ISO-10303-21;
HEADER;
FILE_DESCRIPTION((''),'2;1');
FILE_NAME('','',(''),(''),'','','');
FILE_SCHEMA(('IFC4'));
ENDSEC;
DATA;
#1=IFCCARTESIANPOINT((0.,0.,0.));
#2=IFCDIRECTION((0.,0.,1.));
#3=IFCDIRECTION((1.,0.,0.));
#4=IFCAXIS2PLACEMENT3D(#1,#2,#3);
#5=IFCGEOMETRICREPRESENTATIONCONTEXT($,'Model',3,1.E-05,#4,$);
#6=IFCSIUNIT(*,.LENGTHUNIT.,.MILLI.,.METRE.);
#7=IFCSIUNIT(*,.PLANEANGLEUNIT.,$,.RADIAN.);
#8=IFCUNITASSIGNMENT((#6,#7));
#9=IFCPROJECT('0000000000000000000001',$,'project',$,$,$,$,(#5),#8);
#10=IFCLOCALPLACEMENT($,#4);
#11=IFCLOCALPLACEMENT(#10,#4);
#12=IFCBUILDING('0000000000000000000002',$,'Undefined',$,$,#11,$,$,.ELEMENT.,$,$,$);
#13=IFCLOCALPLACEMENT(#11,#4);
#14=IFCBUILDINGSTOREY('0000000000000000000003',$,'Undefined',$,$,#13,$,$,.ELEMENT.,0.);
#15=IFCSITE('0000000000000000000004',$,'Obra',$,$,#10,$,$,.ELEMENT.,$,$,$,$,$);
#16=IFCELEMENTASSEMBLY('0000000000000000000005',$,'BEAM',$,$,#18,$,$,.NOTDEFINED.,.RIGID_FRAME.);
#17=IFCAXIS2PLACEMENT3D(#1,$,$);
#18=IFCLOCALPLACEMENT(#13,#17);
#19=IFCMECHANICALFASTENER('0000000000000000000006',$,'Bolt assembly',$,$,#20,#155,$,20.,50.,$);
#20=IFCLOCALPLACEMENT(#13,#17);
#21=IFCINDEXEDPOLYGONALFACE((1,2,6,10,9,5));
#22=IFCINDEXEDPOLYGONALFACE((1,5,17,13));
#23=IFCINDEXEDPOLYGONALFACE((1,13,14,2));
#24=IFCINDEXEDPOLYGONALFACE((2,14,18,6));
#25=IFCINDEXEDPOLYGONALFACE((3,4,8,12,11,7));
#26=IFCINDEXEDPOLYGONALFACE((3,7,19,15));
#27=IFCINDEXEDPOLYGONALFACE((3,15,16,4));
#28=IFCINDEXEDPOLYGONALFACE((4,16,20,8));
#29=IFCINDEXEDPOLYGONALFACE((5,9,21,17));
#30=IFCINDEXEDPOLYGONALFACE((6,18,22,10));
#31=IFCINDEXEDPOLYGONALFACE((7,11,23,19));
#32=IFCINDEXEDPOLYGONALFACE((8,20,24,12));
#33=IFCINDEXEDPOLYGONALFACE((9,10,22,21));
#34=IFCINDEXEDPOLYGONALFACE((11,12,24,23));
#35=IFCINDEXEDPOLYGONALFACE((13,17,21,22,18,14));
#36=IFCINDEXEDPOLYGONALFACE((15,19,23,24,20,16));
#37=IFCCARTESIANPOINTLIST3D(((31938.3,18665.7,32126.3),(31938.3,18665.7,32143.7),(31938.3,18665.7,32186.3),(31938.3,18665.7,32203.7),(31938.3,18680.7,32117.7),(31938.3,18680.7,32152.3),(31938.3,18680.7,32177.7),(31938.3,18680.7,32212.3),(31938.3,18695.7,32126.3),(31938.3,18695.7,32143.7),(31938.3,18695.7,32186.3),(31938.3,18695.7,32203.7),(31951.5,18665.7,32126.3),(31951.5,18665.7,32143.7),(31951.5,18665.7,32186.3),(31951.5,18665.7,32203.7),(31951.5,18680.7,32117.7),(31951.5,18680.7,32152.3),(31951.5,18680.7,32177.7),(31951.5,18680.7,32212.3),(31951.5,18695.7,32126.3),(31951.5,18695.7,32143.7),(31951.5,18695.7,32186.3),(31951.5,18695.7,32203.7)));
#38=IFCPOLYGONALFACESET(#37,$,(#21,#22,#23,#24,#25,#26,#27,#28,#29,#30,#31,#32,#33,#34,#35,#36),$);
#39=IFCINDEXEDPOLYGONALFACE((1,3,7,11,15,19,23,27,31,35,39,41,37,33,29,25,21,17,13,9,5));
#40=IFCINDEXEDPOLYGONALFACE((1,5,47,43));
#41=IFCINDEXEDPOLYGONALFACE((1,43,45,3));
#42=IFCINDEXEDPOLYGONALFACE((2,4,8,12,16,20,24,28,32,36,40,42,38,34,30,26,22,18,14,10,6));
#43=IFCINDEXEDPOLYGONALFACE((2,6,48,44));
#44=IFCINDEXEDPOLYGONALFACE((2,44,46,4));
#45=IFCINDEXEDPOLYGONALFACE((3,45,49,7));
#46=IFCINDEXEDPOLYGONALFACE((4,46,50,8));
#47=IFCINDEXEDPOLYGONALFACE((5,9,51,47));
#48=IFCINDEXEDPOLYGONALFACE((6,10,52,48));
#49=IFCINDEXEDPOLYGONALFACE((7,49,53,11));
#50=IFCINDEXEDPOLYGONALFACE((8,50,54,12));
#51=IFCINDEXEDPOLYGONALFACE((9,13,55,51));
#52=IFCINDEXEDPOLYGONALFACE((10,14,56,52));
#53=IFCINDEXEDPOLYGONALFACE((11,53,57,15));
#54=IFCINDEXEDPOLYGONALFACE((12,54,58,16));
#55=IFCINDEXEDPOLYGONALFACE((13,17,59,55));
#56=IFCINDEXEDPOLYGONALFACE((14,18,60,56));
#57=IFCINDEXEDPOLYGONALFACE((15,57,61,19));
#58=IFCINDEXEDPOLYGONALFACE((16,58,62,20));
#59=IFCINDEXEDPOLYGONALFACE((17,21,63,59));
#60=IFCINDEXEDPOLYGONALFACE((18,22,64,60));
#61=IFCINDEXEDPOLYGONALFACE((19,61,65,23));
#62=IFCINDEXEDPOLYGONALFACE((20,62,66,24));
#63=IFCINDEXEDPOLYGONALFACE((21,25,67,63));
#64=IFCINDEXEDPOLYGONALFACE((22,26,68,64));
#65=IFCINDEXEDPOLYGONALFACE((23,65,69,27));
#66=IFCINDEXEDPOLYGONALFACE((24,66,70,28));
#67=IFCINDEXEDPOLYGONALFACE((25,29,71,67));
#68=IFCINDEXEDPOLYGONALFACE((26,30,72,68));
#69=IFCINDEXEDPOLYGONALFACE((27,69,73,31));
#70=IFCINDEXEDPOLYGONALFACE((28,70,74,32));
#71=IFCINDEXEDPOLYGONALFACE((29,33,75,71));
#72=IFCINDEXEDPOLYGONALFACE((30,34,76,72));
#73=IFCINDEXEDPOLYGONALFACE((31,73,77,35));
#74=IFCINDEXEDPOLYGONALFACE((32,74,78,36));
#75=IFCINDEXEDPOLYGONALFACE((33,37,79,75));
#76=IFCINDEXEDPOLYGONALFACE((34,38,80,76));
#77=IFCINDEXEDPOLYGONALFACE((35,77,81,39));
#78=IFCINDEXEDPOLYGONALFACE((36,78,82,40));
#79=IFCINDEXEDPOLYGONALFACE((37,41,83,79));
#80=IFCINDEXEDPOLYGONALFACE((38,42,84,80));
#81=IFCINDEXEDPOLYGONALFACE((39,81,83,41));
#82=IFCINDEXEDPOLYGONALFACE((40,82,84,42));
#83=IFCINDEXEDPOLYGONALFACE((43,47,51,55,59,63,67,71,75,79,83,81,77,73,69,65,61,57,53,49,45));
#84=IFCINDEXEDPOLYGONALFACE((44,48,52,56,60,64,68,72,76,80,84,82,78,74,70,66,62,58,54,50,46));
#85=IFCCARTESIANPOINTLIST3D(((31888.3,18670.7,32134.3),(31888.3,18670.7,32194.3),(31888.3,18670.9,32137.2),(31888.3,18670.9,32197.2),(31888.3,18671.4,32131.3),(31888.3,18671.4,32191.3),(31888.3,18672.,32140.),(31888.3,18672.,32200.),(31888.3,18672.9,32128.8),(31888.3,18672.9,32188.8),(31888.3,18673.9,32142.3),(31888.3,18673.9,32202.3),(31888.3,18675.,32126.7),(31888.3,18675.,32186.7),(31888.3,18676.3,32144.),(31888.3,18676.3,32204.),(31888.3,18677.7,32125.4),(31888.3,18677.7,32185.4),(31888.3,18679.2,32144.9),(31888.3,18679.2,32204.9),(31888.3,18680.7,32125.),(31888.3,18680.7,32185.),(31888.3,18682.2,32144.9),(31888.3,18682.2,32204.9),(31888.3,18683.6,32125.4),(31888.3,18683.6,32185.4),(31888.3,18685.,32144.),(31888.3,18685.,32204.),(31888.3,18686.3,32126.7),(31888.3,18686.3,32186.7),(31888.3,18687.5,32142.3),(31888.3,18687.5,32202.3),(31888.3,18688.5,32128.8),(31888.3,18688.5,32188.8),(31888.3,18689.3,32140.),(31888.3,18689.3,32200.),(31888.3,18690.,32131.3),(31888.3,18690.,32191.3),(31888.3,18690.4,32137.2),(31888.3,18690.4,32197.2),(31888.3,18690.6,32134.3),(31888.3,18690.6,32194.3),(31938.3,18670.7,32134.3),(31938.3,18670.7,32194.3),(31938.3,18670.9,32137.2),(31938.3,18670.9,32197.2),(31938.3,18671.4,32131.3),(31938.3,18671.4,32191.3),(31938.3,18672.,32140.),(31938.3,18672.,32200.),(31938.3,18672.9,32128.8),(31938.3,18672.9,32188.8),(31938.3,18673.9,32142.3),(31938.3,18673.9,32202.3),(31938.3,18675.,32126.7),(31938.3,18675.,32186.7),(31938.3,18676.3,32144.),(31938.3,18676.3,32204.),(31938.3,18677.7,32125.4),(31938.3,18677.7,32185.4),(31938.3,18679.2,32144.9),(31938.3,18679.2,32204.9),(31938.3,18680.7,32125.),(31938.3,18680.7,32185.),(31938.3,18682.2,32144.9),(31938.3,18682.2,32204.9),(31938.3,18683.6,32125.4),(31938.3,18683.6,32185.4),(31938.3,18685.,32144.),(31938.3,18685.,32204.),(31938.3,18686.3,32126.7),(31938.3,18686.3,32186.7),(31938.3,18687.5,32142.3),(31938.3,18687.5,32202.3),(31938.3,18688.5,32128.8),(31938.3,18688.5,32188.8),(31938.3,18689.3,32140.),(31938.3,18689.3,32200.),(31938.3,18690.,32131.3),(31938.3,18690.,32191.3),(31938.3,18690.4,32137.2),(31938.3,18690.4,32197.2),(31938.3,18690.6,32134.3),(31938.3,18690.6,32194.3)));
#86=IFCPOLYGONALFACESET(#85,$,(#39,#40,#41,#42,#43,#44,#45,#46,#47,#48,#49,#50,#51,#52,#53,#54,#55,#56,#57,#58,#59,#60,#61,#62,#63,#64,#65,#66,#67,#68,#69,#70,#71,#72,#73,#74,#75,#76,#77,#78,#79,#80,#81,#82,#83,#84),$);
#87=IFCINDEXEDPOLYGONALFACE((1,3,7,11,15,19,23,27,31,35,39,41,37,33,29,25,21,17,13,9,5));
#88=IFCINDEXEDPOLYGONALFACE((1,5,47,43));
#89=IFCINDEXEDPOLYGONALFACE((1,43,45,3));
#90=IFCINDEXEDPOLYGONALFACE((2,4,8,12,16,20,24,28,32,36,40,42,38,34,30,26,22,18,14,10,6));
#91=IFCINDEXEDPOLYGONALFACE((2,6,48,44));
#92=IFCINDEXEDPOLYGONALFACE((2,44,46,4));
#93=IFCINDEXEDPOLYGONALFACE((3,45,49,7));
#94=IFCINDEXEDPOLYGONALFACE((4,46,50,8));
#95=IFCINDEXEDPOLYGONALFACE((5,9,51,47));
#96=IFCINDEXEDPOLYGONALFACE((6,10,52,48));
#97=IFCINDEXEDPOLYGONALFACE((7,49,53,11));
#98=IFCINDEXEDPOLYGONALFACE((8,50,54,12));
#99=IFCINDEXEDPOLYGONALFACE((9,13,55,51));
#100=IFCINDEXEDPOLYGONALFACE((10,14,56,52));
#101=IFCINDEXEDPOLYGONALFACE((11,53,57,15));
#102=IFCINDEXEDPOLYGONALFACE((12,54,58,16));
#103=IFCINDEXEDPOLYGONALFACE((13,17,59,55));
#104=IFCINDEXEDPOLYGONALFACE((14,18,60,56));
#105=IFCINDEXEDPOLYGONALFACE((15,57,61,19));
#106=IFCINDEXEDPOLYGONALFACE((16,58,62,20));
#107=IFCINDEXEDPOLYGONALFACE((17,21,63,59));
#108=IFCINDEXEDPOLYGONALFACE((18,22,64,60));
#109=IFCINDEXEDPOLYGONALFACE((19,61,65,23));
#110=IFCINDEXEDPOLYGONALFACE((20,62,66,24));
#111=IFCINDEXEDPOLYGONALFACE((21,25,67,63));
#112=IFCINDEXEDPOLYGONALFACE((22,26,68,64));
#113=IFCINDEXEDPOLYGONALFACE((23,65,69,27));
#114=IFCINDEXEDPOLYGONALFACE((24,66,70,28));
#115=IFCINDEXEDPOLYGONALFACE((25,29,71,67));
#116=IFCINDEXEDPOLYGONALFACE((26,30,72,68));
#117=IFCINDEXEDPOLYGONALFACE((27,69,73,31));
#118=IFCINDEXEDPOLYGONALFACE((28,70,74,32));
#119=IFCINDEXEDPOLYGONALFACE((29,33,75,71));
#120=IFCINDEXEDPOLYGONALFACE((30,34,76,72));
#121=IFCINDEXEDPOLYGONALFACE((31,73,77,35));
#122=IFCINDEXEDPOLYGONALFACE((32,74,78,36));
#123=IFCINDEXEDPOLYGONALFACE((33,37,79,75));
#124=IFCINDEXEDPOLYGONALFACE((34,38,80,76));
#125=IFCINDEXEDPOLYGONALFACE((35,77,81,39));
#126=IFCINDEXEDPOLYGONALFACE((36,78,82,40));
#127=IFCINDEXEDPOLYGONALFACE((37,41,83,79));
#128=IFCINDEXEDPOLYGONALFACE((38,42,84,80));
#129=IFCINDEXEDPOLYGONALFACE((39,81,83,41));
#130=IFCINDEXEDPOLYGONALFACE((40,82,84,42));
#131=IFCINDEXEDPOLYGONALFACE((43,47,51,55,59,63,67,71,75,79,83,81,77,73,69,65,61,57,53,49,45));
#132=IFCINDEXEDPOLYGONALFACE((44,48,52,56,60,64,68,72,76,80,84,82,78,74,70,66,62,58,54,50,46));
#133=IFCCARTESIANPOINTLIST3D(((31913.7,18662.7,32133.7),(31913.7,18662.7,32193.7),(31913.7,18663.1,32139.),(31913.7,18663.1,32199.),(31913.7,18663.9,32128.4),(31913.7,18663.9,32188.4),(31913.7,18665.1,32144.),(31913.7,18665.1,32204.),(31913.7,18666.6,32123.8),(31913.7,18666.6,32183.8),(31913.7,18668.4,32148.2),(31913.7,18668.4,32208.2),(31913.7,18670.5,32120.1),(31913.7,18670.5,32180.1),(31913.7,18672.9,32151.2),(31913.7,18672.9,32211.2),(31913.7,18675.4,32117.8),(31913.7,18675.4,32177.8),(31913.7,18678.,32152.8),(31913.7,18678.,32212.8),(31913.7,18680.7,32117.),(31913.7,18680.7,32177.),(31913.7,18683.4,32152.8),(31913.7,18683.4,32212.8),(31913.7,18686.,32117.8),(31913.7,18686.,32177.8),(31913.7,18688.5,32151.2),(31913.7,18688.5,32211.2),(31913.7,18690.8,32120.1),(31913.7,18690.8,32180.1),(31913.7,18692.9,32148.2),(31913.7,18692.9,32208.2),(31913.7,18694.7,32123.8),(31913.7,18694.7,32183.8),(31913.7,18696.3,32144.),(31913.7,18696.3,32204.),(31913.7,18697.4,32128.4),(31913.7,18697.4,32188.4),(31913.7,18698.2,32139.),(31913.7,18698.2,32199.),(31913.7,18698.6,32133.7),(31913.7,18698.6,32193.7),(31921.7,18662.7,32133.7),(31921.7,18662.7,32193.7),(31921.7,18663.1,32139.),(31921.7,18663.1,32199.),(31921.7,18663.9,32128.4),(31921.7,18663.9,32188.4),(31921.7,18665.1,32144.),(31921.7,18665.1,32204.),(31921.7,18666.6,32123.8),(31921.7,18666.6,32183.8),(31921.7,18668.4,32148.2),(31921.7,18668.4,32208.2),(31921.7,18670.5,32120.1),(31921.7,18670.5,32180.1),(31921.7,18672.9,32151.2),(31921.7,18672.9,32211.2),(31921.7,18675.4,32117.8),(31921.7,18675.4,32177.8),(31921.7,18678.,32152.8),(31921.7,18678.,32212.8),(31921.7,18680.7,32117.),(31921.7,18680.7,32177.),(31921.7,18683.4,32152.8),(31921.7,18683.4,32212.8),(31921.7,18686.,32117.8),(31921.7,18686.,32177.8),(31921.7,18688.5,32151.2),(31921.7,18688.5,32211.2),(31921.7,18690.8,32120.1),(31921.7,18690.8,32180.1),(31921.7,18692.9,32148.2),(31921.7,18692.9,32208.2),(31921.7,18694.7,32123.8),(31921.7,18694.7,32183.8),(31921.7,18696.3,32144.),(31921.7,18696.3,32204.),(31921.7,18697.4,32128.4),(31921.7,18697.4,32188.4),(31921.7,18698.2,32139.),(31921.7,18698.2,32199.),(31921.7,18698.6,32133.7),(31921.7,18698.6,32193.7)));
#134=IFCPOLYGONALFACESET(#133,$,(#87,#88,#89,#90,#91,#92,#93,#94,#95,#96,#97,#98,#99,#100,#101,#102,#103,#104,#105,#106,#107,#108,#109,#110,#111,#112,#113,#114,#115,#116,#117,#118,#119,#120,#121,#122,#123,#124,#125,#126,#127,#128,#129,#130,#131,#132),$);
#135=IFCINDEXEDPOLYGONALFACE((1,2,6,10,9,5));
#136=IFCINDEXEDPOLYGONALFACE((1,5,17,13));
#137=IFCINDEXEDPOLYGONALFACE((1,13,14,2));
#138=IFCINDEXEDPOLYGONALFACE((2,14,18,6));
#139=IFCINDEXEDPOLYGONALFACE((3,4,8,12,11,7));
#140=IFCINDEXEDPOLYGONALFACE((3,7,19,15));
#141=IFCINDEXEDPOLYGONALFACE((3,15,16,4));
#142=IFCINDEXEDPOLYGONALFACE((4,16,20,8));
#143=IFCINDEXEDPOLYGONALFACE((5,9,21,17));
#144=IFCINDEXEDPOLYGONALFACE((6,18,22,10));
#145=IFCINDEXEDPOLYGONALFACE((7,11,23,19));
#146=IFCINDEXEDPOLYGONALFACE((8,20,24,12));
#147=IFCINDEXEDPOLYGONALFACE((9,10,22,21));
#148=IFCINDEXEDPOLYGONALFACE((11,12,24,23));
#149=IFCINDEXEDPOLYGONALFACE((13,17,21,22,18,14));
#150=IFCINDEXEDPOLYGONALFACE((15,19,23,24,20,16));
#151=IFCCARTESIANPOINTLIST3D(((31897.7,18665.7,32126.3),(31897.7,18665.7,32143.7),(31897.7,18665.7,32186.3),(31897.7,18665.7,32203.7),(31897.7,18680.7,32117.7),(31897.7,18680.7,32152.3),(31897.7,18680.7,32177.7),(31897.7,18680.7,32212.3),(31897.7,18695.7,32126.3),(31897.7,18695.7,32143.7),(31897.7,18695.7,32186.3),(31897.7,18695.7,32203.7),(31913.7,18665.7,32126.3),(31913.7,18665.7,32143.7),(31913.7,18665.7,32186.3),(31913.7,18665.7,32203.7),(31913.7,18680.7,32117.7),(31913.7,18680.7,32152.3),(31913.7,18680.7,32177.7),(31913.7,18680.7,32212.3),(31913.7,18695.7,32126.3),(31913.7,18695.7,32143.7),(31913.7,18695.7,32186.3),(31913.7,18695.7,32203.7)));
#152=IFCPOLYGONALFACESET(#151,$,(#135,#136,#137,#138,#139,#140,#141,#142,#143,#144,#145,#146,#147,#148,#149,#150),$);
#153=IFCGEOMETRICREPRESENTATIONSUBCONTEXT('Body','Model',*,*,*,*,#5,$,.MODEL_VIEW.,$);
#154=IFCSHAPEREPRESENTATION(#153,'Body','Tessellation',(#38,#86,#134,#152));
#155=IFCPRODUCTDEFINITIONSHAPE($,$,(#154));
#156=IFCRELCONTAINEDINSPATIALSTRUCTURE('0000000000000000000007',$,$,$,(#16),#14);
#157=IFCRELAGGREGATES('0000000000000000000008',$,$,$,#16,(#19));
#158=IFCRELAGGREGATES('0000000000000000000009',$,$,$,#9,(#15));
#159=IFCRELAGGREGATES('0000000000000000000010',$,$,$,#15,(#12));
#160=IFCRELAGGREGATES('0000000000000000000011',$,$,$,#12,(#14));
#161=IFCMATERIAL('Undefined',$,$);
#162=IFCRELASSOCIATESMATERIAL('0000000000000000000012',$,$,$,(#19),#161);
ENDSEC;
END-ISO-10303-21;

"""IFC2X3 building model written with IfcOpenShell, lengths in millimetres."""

from ifc_helpers import new_model, si_unit, frame, origin_with_axes, origin_2d_with_axis, place, context, subcontext, project, spatial, polyline, circle, outline, extrude, source, transform, mapped, material, element, aggregate, save


model = new_model("IFC2X3")

# Units and contexts
model_context = context("Model", 3, precision=1e-05, world=origin_with_axes())
body_context = subcontext(model_context, "Body", "Model", "MODEL_VIEW")
ifc_project = project(units=[si_unit("LENGTHUNIT", "METRE", prefix="MILLI"), si_unit("PLANEANGLEUNIT", "RADIAN")], contexts=[model_context])

# Site, building, storey
site_placement = place(None, origin_with_axes())
site = spatial("IfcSite", under=ifc_project, at=site_placement, Name="Obra", CompositionType="ELEMENT")
building_placement = place(site_placement, origin_with_axes())
building = spatial("IfcBuilding", under=site, at=building_placement, Name="Undefined", CompositionType="ELEMENT")
storey_placement = place(building_placement, origin_with_axes())
storey = spatial("IfcBuildingStorey", under=building, at=storey_placement, Name="Undefined", CompositionType="ELEMENT", Elevation=0.0)

# Element assembly
assembly_1_placement = place(storey_placement, origin_with_axes())
assembly_1 = element("IfcElementAssembly", 1, at=assembly_1_placement, inside=storey, Name="BEAM", AssemblyPlace="NOTDEFINED", PredefinedType="RIGID_FRAME")

# Shared definitions
ifc_material_1 = material(Name="Undefined")
shared_shape_1 = source(origin_with_axes(), body_context, "Body", "SweptSolid", [
    extrude(outline(polyline([(17.3, 0.0), (8.7, 15.0), (-8.7, 15.0), (-17.3, 0.0), (-8.7, -15.0), (8.7, -15.0), (17.3, 0.0)])), frame((0.0, -26.5, 0.0), z_axis=(0.0, 1.0, 0.0), x_axis=(1.0, 0.0, 0.0)), (0.0, 0.0, 1.0), 13.2),
    extrude(circle(Radius=10.0, at=origin_2d_with_axis()), frame((0.0, -13.3, 0.0), z_axis=(0.0, 1.0, 0.0), x_axis=(1.0, 0.0, 0.0)), (0.0, 0.0, 1.0), 50.0),
    extrude(circle(Radius=18.0, at=origin_2d_with_axis()), frame((0.0, 3.3, 0.0), z_axis=(0.0, 1.0, 0.0), x_axis=(1.0, 0.0, 0.0)), (0.0, 0.0, 1.0), 8.0),
    extrude(outline(polyline([(17.3, 0.0), (8.7, 15.0), (-8.7, 15.0), (-17.3, 0.0), (-8.7, -15.0), (8.7, -15.0), (17.3, 0.0)])), frame((0.0, 11.3, 0.0), z_axis=(0.0, 1.0, 0.0), x_axis=(1.0, 0.0, 0.0)), (0.0, 0.0, 1.0), 16.0),
])

# Mechanical fastener
mechanical_fastener_1_placement = place(assembly_1_placement, frame((31925.0, 18640.7, 32235.0), z_axis=(0.0, 1.0, 0.0), x_axis=(0.0, 0.0, -1.0)))
mechanical_fastener_1 = element("IfcMechanicalFastener", 2, at=mechanical_fastener_1_placement, material=ifc_material_1, Name="Bolt assembly", NominalDiameter=20.0, NominalLength=50.0, context=body_context, shape_type="MappedRepresentation", body=[
    mapped(shared_shape_1, transform((40.0, 0.0, 40.0))),
    mapped(shared_shape_1, transform((100.0, 0.0, 40.0))),
])

aggregate(assembly_1, [mechanical_fastener_1])

save(model, "model.ifc")
